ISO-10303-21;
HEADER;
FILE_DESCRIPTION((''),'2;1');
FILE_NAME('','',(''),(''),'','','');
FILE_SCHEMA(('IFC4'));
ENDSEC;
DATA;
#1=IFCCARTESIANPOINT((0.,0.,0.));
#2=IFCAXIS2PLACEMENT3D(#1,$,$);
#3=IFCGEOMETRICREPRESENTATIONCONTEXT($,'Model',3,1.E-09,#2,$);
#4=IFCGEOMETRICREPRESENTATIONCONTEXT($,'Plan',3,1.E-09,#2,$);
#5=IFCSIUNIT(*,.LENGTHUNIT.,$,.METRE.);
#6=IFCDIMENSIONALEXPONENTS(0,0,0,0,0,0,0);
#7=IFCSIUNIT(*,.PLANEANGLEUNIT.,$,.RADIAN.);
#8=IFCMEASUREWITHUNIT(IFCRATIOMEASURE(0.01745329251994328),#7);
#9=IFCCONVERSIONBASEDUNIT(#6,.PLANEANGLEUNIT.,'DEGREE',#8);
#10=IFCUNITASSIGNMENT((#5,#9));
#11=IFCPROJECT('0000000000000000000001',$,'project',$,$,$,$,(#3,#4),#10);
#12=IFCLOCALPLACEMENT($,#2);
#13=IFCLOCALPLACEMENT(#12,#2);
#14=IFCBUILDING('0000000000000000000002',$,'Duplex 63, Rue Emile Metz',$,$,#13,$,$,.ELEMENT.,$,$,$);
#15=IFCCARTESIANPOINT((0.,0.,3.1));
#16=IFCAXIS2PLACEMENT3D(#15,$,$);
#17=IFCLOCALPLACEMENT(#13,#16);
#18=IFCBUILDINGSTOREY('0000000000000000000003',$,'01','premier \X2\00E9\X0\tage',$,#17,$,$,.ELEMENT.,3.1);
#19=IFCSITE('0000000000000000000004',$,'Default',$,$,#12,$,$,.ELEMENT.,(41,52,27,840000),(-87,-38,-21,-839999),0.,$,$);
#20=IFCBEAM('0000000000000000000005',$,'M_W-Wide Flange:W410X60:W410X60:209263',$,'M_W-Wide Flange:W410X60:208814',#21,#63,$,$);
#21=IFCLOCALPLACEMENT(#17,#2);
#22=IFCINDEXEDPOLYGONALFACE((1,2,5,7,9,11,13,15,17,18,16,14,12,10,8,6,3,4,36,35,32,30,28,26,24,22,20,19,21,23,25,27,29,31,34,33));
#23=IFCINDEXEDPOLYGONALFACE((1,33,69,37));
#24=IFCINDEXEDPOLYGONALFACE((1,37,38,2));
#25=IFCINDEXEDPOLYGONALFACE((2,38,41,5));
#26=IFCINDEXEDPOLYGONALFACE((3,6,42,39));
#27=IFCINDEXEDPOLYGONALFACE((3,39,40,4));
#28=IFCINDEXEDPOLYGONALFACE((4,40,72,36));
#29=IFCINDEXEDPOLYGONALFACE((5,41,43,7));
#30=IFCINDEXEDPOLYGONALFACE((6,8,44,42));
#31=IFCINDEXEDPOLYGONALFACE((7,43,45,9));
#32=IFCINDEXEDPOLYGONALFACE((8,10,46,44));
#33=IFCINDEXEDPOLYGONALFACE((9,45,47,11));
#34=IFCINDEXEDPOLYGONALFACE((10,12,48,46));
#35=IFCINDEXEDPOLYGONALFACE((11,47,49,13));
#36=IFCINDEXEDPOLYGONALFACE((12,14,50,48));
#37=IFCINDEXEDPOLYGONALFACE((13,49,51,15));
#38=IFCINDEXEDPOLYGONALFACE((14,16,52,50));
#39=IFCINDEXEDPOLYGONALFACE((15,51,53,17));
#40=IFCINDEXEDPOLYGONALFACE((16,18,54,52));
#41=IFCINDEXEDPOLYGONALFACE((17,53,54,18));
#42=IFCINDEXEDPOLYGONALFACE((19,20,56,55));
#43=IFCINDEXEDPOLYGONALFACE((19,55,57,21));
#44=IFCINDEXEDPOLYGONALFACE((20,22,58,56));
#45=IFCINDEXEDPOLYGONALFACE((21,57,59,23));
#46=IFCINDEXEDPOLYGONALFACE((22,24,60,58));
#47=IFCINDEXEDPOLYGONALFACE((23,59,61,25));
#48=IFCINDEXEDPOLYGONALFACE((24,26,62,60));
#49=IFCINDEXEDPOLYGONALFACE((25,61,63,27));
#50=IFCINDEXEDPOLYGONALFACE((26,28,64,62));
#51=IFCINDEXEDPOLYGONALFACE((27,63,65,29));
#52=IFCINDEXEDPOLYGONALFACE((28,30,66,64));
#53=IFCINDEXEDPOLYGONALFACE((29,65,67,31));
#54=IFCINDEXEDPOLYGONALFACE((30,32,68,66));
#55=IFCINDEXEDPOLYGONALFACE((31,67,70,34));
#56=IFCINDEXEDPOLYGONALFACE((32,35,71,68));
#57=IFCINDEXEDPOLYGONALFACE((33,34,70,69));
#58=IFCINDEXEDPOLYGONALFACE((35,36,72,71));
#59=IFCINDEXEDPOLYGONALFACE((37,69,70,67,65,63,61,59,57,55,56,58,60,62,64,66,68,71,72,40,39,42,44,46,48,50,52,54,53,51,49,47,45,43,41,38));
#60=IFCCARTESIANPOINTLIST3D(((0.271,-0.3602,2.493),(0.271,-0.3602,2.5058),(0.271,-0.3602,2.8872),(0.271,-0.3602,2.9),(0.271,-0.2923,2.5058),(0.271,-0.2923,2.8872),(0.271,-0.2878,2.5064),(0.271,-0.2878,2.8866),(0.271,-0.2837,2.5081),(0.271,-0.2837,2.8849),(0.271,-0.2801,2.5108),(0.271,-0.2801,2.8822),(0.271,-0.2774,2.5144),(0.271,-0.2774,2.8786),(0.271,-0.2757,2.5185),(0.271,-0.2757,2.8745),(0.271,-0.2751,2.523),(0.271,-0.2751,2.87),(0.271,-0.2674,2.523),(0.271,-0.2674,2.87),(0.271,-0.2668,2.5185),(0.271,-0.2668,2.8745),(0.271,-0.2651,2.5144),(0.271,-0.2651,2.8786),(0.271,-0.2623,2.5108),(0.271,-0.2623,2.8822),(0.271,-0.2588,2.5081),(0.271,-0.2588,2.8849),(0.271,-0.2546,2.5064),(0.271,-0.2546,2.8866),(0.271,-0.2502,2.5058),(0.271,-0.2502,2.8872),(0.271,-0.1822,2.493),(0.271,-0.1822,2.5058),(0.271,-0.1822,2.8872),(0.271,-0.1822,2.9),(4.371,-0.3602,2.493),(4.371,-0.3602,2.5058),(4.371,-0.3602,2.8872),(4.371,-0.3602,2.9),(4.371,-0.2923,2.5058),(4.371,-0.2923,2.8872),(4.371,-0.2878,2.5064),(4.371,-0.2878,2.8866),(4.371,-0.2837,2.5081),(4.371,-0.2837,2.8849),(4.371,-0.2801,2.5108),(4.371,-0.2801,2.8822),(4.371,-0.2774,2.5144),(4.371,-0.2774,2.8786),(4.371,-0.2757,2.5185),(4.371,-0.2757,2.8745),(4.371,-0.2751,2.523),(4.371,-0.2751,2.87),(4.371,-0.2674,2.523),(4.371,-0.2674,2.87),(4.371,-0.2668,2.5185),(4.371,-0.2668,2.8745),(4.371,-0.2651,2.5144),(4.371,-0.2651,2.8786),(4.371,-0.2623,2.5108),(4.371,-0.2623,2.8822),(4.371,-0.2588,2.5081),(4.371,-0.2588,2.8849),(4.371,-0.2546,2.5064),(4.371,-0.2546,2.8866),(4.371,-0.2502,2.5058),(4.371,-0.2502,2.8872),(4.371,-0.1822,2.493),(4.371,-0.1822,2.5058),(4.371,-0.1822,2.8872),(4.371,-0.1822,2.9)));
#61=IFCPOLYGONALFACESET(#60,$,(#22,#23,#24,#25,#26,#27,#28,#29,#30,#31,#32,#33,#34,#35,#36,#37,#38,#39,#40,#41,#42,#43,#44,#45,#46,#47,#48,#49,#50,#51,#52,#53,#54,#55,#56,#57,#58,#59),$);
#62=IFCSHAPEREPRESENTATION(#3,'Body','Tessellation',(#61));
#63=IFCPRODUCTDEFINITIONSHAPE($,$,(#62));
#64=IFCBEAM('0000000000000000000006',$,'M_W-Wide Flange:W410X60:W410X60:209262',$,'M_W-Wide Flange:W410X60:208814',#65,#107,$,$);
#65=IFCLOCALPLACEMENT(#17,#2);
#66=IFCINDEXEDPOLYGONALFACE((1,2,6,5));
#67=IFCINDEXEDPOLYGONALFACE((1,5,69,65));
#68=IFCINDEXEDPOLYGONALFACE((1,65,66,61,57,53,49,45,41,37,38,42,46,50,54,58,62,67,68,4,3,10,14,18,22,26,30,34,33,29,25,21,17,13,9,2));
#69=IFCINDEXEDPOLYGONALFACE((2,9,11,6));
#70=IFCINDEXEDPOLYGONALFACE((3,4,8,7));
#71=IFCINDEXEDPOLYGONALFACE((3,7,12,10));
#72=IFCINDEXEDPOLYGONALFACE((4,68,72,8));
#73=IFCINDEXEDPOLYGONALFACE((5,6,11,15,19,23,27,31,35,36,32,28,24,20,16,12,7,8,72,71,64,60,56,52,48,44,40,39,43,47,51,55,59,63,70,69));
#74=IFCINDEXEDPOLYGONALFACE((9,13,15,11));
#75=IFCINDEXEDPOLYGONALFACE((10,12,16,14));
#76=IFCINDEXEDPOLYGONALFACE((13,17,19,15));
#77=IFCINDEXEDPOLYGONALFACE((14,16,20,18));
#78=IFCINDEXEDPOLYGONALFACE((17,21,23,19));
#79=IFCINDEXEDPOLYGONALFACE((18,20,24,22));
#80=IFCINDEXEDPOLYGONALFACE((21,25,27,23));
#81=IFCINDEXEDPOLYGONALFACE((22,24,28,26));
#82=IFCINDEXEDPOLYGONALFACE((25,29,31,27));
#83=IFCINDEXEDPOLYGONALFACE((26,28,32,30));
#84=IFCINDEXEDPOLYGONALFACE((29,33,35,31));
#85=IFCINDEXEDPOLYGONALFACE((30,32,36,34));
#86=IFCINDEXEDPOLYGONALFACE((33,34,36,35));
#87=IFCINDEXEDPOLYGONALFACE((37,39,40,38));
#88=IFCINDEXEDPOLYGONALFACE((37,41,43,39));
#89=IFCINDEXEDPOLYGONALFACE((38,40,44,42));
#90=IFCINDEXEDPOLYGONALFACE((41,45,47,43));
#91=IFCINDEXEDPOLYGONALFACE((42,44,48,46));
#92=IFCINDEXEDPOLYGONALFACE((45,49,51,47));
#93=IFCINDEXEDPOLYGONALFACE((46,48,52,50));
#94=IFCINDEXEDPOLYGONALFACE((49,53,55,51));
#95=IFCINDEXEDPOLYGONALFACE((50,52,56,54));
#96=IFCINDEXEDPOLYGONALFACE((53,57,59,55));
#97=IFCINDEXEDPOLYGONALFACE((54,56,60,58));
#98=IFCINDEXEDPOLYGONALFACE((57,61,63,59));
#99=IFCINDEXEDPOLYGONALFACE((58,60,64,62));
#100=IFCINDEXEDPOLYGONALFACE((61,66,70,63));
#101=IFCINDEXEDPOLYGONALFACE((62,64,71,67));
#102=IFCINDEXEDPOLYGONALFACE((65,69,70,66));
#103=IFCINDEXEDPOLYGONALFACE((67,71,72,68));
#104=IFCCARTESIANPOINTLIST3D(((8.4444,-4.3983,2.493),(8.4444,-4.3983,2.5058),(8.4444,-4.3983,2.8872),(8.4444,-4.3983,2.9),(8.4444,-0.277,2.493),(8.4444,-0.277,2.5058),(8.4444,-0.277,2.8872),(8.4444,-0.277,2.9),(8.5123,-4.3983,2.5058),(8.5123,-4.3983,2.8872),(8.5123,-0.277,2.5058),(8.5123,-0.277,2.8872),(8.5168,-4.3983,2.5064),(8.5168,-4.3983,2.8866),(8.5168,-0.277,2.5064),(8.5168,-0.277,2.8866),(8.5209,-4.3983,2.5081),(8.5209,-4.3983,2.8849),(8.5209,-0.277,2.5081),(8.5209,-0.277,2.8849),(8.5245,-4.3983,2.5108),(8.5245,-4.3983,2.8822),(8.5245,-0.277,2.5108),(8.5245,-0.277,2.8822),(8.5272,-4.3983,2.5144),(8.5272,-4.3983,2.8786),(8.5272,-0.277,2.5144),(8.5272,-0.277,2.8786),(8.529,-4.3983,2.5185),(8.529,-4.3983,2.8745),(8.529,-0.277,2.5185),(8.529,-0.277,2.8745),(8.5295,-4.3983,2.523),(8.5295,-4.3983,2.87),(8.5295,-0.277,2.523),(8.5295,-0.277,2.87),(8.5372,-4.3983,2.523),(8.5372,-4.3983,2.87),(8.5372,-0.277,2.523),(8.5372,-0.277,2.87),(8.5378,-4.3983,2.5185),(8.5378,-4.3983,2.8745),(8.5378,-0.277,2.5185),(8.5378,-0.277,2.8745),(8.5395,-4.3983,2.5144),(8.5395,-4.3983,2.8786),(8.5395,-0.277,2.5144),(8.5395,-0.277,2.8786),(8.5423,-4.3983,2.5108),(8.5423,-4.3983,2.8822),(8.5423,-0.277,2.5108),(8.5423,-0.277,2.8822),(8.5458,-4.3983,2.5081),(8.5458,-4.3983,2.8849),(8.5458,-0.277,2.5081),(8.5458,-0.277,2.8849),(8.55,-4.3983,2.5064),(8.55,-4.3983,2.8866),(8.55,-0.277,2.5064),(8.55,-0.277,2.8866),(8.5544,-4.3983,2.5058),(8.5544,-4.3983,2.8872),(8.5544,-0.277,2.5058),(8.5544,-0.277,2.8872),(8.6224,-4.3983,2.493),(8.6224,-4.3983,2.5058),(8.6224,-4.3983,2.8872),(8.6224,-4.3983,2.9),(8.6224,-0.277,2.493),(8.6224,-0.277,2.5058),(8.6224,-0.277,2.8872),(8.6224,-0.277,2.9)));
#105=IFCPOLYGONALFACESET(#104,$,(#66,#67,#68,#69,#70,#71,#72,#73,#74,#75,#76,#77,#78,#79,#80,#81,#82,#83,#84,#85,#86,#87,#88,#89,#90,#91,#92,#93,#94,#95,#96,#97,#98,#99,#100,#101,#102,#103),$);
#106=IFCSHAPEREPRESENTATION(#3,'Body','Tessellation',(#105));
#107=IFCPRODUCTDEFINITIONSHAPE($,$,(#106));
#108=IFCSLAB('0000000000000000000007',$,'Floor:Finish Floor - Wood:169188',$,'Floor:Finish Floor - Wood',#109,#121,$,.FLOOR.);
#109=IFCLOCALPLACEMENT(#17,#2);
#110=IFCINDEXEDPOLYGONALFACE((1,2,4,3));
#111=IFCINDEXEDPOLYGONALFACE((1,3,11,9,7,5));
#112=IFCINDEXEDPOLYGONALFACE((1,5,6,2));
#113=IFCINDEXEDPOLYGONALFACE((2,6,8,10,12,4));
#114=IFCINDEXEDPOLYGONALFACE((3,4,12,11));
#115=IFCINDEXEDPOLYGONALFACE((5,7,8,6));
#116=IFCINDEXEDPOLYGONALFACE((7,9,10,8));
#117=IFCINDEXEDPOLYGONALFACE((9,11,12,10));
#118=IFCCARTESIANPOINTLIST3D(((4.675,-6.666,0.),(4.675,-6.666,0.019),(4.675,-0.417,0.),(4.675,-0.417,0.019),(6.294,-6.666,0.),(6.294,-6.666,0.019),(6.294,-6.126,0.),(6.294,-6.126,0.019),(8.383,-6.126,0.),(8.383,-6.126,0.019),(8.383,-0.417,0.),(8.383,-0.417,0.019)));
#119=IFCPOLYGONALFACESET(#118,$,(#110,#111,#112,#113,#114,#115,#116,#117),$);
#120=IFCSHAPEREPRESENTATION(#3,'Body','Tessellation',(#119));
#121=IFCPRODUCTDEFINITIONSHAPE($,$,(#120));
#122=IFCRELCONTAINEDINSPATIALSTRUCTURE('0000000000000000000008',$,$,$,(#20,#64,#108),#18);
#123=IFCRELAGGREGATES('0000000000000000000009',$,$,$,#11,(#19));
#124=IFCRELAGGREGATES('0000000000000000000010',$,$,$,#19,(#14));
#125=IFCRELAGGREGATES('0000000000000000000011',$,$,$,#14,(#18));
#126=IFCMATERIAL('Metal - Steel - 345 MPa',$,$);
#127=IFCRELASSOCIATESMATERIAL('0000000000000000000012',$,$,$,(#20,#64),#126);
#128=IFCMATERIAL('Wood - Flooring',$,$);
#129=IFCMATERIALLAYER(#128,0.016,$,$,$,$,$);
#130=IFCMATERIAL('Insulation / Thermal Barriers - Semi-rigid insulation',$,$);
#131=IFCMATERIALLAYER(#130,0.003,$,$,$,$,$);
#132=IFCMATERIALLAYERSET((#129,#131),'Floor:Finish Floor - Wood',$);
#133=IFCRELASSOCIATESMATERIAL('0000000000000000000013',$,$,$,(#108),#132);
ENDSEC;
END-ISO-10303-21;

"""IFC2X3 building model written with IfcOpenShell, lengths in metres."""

from ifc_helpers import new_model, entity, si_unit, converted_unit, frame, frame_2d, origin, place, context, project, spatial, polyline, circle_curve, parameter, trimmed, segment, composite_curve, outline, extrude, material, layer, layer_set, layer_usage, element, save


model = new_model("IFC2X3")

# Units and contexts
model_context = context("Model", 3, precision=1e-09, world=origin())
plan_context = context("Plan", 3, precision=1e-09, world=origin())
ifc_project = project(units=[si_unit("LENGTHUNIT", "METRE"), converted_unit("PLANEANGLEUNIT", "DEGREE", entity("IfcRatioMeasure", 0.01745329251994328), si_unit("PLANEANGLEUNIT", "RADIAN"), dimensions=[0, 0, 0, 0, 0, 0, 0])], contexts=[model_context, plan_context])

# Site, building, storey
site_placement = place(None, origin())
site = spatial("IfcSite", under=ifc_project, at=site_placement, Name="Default", CompositionType="ELEMENT", RefLatitude=(41, 52, 27, 840000), RefLongitude=(-87, -38, -21, -839999), RefElevation=0.0)
building_placement = place(site_placement, origin())
building = spatial("IfcBuilding", under=site, at=building_placement, Name="Duplex 63, Rue Emile Metz", CompositionType="ELEMENT")
storey_placement = place(building_placement, frame((0.0, 0.0, 3.1)))
storey = spatial("IfcBuildingStorey", under=building, at=storey_placement, Name="01", Description="premier étage", CompositionType="ELEMENT", Elevation=3.1)

# Beams
ifc_material_1 = material(Name="Metal - Steel - 345 MPa")
beam_1_placement = place(storey_placement, frame((4.371, -0.2712, 2.9), z_axis=(0.0, 0.0, 1.0), x_axis=(0.0, 1.0, 0.0)))
element("IfcBeam", 1, at=beam_1_placement, inside=storey, material=ifc_material_1, Name="M_W-Wide Flange:W410X60:W410X60:209263", ObjectType="M_W-Wide Flange:W410X60:208814", context=model_context, shape_type="SweptSolid", body=[
    extrude(outline(composite_curve([segment(polyline([(0.1907, -0.089), (0.2035, -0.089)]), True, "CONTINUOUS"), segment(polyline([(0.2035, -0.089), (0.2035, 0.089)]), True, "CONTINUOUS"), segment(polyline([(0.2035, 0.089), (0.1907, 0.089)]), True, "CONTINUOUS"), segment(polyline([(0.1907, 0.089), (0.1907, 0.0211)]), True, "CONTINUOUS"), segment(trimmed(circle_curve(frame_2d((0.1735, 0.0211), x_axis=(1.0, 0.0)), 0.0172), [parameter(270.0)], [parameter(360.0)], True, "PARAMETER"), False, "CONTINUOUS"), segment(polyline([(0.1735, 0.0039), (-0.1735, 0.0039)]), True, "CONTINUOUS"), segment(trimmed(circle_curve(frame_2d((-0.1735, 0.0211), x_axis=(0.0, -1.0)), 0.0172), [parameter(270.0)], [parameter(360.0)], True, "PARAMETER"), False, "CONTINUOUS"), segment(polyline([(-0.1907, 0.0211), (-0.1907, 0.089)]), True, "CONTINUOUS"), segment(polyline([(-0.1907, 0.089), (-0.2035, 0.089)]), True, "CONTINUOUS"), segment(polyline([(-0.2035, 0.089), (-0.2035, -0.089)]), True, "CONTINUOUS"), segment(polyline([(-0.2035, -0.089), (-0.1907, -0.089)]), True, "CONTINUOUS"), segment(polyline([(-0.1907, -0.089), (-0.1907, -0.0211)]), True, "CONTINUOUS"), segment(trimmed(circle_curve(frame_2d((-0.1735, -0.0211), x_axis=(-1.0, 0.0)), 0.0172), [parameter(270.0)], [parameter(0.0)], True, "PARAMETER"), False, "CONTINUOUS"), segment(polyline([(-0.1735, -0.0039), (0.1735, -0.0039)]), True, "CONTINUOUS"), segment(trimmed(circle_curve(frame_2d((0.1735, -0.0211), x_axis=(0.0, 1.0)), 0.0172), [parameter(270.0)], [parameter(0.0)], True, "PARAMETER"), False, "CONTINUOUS"), segment(polyline([(0.1907, -0.0211), (0.1907, -0.089)]), True, "CONTINUOUS")], self_intersect=False)), frame((0.0, 4.1, -0.2035), z_axis=(0.0, -1.0, 0.0), x_axis=(0.0, 0.0, -1.0)), (0.0, 0.0, 1.0), 4.1),
])
beam_2_placement = place(storey_placement, frame((8.5334, -4.3983, 2.9)))
element("IfcBeam", 2, at=beam_2_placement, inside=storey, material=ifc_material_1, Name="M_W-Wide Flange:W410X60:W410X60:209262", ObjectType="M_W-Wide Flange:W410X60:208814", context=model_context, shape_type="SweptSolid", body=[
    extrude(outline(composite_curve([segment(polyline([(-0.089, -0.1907), (-0.089, -0.2035)]), True, "CONTINUOUS"), segment(polyline([(-0.089, -0.2035), (0.089, -0.2035)]), True, "CONTINUOUS"), segment(polyline([(0.089, -0.2035), (0.089, -0.1907)]), True, "CONTINUOUS"), segment(polyline([(0.089, -0.1907), (0.021, -0.1907)]), True, "CONTINUOUS"), segment(trimmed(circle_curve(frame_2d((0.021, -0.1735), x_axis=(0.0, -1.0)), 0.0172), [parameter(270.0)], [parameter(360.0)], True, "PARAMETER"), False, "CONTINUOUS"), segment(polyline([(0.0038, -0.1735), (0.0038, 0.1735)]), True, "CONTINUOUS"), segment(trimmed(circle_curve(frame_2d((0.021, 0.1735), x_axis=(-1.0, 0.0)), 0.0172), [parameter(270.0)], [parameter(360.0)], True, "PARAMETER"), False, "CONTINUOUS"), segment(polyline([(0.021, 0.1907), (0.089, 0.1907)]), True, "CONTINUOUS"), segment(polyline([(0.089, 0.1907), (0.089, 0.2035)]), True, "CONTINUOUS"), segment(polyline([(0.089, 0.2035), (-0.089, 0.2035)]), True, "CONTINUOUS"), segment(polyline([(-0.089, 0.2035), (-0.089, 0.1907)]), True, "CONTINUOUS"), segment(polyline([(-0.089, 0.1907), (-0.0211, 0.1907)]), True, "CONTINUOUS"), segment(trimmed(circle_curve(frame_2d((-0.0211, 0.1735), x_axis=(0.0, 1.0)), 0.0172), [parameter(270.0)], [parameter(0.0)], True, "PARAMETER"), False, "CONTINUOUS"), segment(polyline([(-0.0039, 0.1735), (-0.0039, -0.1735)]), True, "CONTINUOUS"), segment(trimmed(circle_curve(frame_2d((-0.0211, -0.1735), x_axis=(1.0, 0.0)), 0.0172), [parameter(270.0)], [parameter(0.0)], True, "PARAMETER"), False, "CONTINUOUS"), segment(polyline([(-0.0211, -0.1907), (-0.089, -0.1907)]), True, "CONTINUOUS")], self_intersect=False)), frame((0.0, 0.0, -0.2035), z_axis=(0.0, -1.0, 0.0), x_axis=(1.0, 0.0, 0.0)), (0.0, 0.0, -1.0), 4.1213),
])

# Slab
ifc_material_2 = material(Name="Wood - Flooring")
ifc_layer_1 = layer(ifc_material_2, 0.016)
ifc_material_3 = material(Name="Insulation / Thermal Barriers - Semi-rigid insulation")
ifc_layer_2 = layer(ifc_material_3, 0.003)
ifc_layer_set_1 = layer_set([ifc_layer_1, ifc_layer_2], Name="Floor:Finish Floor - Wood")
ifc_layer_usage_1 = layer_usage(ifc_layer_set_1, "AXIS3", "POSITIVE", 0.0)
slab_placement = place(storey_placement, frame((4.675, -6.666, 0.0)))
element("IfcSlab", 3, at=slab_placement, inside=storey, material=ifc_layer_usage_1, Name="Floor:Finish Floor - Wood:169188", ObjectType="Floor:Finish Floor - Wood", PredefinedType="FLOOR", context=model_context, shape_type="SweptSolid", body=[
    extrude(outline(polyline([(-1.854, 3.1245), (-1.854, -2.5845), (0.235, -2.5845), (0.235, -3.1245), (1.854, -3.1245), (1.854, 3.1245), (-1.854, 3.1245)])), frame((1.854, 3.1245, 0.019), z_axis=(0.0, 0.0, -1.0), x_axis=(-1.0, 0.0, 0.0)), (0.0, 0.0, 1.0), 0.019),
])

save(model, "model.ifc")
